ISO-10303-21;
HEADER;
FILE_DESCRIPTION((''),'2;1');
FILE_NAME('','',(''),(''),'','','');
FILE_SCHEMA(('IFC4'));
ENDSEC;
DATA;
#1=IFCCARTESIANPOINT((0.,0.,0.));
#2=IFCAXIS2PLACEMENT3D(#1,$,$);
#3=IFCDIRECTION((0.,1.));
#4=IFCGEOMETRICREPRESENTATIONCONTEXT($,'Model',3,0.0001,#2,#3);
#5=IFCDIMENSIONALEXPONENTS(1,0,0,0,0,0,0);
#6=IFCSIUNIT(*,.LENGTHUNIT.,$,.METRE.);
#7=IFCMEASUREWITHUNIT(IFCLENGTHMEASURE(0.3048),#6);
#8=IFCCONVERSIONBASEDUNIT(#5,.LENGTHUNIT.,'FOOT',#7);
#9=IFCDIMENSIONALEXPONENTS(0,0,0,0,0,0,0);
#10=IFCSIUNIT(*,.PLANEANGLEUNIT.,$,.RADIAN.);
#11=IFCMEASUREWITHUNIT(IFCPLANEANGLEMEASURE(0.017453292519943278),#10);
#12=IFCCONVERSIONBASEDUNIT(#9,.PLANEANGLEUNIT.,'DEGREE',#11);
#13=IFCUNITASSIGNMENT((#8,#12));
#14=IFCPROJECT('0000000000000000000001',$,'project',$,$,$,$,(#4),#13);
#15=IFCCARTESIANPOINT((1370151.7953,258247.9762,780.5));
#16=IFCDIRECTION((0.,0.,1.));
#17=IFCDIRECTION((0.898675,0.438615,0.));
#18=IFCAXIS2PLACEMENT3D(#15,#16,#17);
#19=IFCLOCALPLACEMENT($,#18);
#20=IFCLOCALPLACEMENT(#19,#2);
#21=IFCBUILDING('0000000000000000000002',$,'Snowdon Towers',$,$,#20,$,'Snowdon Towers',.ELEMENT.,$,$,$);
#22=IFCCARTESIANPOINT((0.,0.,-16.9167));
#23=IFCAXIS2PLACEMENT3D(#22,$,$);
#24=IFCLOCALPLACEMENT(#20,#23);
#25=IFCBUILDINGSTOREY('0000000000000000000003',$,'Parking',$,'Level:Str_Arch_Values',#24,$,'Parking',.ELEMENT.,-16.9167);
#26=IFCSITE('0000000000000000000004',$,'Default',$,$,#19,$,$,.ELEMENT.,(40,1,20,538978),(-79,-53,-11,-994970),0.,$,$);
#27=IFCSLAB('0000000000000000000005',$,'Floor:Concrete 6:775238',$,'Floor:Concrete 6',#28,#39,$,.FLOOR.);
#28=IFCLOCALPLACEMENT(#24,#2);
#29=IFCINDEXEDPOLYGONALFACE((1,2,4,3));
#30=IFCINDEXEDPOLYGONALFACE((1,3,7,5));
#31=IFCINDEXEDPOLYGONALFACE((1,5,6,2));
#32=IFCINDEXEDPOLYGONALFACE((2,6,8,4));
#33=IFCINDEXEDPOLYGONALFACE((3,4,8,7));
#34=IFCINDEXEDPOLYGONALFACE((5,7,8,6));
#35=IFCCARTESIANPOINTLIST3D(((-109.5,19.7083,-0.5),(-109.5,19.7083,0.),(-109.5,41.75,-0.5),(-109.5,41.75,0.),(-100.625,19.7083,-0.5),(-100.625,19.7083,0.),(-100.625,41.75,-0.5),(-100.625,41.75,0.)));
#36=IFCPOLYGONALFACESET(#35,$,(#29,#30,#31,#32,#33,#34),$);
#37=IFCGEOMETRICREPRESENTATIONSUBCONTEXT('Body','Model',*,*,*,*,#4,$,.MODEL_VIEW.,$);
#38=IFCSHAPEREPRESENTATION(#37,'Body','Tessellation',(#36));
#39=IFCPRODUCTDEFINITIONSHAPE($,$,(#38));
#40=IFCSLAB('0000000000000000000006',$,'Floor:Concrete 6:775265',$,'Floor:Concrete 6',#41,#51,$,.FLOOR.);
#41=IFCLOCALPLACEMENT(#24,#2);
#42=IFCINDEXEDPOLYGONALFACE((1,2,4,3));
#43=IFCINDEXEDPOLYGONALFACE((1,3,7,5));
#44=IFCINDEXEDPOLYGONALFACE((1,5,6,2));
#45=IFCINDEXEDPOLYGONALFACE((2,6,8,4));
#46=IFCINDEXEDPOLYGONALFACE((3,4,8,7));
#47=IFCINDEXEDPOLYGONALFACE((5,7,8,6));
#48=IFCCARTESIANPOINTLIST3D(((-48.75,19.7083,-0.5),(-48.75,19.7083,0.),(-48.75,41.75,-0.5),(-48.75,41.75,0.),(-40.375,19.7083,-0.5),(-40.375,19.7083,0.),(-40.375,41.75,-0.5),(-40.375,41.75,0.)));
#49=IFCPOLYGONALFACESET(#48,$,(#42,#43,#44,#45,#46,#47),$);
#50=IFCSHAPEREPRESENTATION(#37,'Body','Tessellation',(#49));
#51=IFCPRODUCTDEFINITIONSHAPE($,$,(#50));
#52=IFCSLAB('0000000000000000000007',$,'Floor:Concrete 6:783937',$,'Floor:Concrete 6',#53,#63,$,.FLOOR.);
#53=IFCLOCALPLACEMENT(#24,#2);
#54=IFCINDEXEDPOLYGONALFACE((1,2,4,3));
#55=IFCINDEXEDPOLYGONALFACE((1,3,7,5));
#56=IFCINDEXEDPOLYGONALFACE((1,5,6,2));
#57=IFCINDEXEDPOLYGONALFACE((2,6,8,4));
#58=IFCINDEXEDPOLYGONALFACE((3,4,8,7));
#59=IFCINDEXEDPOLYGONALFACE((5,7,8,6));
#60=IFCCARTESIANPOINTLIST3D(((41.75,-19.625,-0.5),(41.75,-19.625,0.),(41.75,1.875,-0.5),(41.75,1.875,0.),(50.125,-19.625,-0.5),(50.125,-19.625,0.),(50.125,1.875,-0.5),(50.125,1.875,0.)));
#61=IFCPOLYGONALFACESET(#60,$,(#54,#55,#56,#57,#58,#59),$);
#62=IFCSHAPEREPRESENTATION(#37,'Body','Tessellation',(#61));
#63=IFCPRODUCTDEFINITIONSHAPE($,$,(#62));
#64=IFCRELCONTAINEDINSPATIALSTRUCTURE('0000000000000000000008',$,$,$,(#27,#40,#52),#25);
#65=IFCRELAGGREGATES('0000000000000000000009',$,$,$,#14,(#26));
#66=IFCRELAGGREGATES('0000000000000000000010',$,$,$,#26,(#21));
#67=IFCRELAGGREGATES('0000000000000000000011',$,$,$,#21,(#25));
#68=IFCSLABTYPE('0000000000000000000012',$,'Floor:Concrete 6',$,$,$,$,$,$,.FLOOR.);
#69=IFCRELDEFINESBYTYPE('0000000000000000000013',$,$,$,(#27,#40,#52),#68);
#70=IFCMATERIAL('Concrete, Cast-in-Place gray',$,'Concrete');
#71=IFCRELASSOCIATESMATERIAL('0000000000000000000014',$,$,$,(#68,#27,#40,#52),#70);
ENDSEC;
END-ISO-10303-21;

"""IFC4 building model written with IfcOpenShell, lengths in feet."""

from ifc_helpers import new_model, entity, si_unit, converted_unit, direction, frame, origin, place, context, subcontext, project, spatial, indexed_curve, outline, extrude, material, type_object, element, save


model = new_model("IFC4")

# Units and contexts
model_context = context("Model", 3, precision=0.0001, world=origin(), true_north=direction((0.0, 1.0)))
body_context = subcontext(model_context, "Body", "Model", "MODEL_VIEW")
ifc_project = project(units=[converted_unit("LENGTHUNIT", "FOOT", entity("IfcLengthMeasure", 0.3048), si_unit("LENGTHUNIT", "METRE"), dimensions=[1, 0, 0, 0, 0, 0, 0]), converted_unit("PLANEANGLEUNIT", "DEGREE", entity("IfcPlaneAngleMeasure", 0.017453292519943278), si_unit("PLANEANGLEUNIT", "RADIAN"), dimensions=[0, 0, 0, 0, 0, 0, 0])], contexts=[model_context])

# Site, building, storey
site_placement = place(None, frame((1370151.7953, 258247.9762, 780.5), z_axis=(0.0, 0.0, 1.0), x_axis=(0.898675, 0.438615, 0.0)))
site = spatial("IfcSite", under=ifc_project, at=site_placement, Name="Default", CompositionType="ELEMENT", RefLatitude=(40, 1, 20, 538978), RefLongitude=(-79, -53, -11, -994970), RefElevation=0.0)
building_placement = place(site_placement, origin())
building = spatial("IfcBuilding", under=site, at=building_placement, Name="Snowdon Towers", LongName="Snowdon Towers", CompositionType="ELEMENT")
storey_placement = place(building_placement, frame((0.0, 0.0, -16.9167)))
storey = spatial("IfcBuildingStorey", under=building, at=storey_placement, Name="Parking", ObjectType="Level:Str_Arch_Values", LongName="Parking", CompositionType="ELEMENT", Elevation=-16.9167)

# Shared definitions
ifc_material = material(Name="Concrete, Cast-in-Place gray", Category="Concrete")

# Shared definitions
slab_type_1 = type_object("IfcSlabType", Name="Floor:Concrete 6", PredefinedType="FLOOR", material=ifc_material)

# Slabs
slab_1_placement = place(storey_placement, origin())
element("IfcSlab", 1, at=slab_1_placement, inside=storey, type_object=slab_type_1, material=ifc_material, Name="Floor:Concrete 6:775238", ObjectType="Floor:Concrete 6", PredefinedType="FLOOR", context=body_context, shape_type="SweptSolid", body=[
    extrude(outline(indexed_curve([(-11.0208, -4.4375), (11.0208, -4.4375), (11.0208, 4.4375), (-11.0208, 4.4375), (-11.0208, -4.4375)], self_intersect=False)), frame((-105.0625, 30.7292, 0.0), z_axis=(0.0, 0.0, -1.0), x_axis=(0.0, 1.0, 0.0)), (0.0, 0.0, 1.0), 0.5),
])
slab_2_placement = place(storey_placement, origin())
element("IfcSlab", 2, at=slab_2_placement, inside=storey, type_object=slab_type_1, material=ifc_material, Name="Floor:Concrete 6:775265", ObjectType="Floor:Concrete 6", PredefinedType="FLOOR", context=body_context, shape_type="SweptSolid", body=[
    extrude(outline(indexed_curve([(-11.0208, -4.1875), (11.0208, -4.1875), (11.0208, 4.1875), (-11.0208, 4.1875), (-11.0208, -4.1875)], self_intersect=False)), frame((-44.5625, 30.7292, 0.0), z_axis=(0.0, 0.0, -1.0), x_axis=(0.0, 1.0, 0.0)), (0.0, 0.0, 1.0), 0.5),
])
slab_3_placement = place(storey_placement, origin())
element("IfcSlab", 3, at=slab_3_placement, inside=storey, type_object=slab_type_1, material=ifc_material, Name="Floor:Concrete 6:783937", ObjectType="Floor:Concrete 6", PredefinedType="FLOOR", context=body_context, shape_type="SweptSolid", body=[
    extrude(outline(indexed_curve([(-10.75, -4.1875), (10.75, -4.1875), (10.75, 4.1875), (-10.75, 4.1875), (-10.75, -4.1875)], self_intersect=False)), frame((45.9375, -8.875, 0.0), z_axis=(0.0, 0.0, -1.0), x_axis=(0.0, 1.0, 0.0)), (0.0, 0.0, 1.0), 0.5),
])

save(model, "model.ifc")
